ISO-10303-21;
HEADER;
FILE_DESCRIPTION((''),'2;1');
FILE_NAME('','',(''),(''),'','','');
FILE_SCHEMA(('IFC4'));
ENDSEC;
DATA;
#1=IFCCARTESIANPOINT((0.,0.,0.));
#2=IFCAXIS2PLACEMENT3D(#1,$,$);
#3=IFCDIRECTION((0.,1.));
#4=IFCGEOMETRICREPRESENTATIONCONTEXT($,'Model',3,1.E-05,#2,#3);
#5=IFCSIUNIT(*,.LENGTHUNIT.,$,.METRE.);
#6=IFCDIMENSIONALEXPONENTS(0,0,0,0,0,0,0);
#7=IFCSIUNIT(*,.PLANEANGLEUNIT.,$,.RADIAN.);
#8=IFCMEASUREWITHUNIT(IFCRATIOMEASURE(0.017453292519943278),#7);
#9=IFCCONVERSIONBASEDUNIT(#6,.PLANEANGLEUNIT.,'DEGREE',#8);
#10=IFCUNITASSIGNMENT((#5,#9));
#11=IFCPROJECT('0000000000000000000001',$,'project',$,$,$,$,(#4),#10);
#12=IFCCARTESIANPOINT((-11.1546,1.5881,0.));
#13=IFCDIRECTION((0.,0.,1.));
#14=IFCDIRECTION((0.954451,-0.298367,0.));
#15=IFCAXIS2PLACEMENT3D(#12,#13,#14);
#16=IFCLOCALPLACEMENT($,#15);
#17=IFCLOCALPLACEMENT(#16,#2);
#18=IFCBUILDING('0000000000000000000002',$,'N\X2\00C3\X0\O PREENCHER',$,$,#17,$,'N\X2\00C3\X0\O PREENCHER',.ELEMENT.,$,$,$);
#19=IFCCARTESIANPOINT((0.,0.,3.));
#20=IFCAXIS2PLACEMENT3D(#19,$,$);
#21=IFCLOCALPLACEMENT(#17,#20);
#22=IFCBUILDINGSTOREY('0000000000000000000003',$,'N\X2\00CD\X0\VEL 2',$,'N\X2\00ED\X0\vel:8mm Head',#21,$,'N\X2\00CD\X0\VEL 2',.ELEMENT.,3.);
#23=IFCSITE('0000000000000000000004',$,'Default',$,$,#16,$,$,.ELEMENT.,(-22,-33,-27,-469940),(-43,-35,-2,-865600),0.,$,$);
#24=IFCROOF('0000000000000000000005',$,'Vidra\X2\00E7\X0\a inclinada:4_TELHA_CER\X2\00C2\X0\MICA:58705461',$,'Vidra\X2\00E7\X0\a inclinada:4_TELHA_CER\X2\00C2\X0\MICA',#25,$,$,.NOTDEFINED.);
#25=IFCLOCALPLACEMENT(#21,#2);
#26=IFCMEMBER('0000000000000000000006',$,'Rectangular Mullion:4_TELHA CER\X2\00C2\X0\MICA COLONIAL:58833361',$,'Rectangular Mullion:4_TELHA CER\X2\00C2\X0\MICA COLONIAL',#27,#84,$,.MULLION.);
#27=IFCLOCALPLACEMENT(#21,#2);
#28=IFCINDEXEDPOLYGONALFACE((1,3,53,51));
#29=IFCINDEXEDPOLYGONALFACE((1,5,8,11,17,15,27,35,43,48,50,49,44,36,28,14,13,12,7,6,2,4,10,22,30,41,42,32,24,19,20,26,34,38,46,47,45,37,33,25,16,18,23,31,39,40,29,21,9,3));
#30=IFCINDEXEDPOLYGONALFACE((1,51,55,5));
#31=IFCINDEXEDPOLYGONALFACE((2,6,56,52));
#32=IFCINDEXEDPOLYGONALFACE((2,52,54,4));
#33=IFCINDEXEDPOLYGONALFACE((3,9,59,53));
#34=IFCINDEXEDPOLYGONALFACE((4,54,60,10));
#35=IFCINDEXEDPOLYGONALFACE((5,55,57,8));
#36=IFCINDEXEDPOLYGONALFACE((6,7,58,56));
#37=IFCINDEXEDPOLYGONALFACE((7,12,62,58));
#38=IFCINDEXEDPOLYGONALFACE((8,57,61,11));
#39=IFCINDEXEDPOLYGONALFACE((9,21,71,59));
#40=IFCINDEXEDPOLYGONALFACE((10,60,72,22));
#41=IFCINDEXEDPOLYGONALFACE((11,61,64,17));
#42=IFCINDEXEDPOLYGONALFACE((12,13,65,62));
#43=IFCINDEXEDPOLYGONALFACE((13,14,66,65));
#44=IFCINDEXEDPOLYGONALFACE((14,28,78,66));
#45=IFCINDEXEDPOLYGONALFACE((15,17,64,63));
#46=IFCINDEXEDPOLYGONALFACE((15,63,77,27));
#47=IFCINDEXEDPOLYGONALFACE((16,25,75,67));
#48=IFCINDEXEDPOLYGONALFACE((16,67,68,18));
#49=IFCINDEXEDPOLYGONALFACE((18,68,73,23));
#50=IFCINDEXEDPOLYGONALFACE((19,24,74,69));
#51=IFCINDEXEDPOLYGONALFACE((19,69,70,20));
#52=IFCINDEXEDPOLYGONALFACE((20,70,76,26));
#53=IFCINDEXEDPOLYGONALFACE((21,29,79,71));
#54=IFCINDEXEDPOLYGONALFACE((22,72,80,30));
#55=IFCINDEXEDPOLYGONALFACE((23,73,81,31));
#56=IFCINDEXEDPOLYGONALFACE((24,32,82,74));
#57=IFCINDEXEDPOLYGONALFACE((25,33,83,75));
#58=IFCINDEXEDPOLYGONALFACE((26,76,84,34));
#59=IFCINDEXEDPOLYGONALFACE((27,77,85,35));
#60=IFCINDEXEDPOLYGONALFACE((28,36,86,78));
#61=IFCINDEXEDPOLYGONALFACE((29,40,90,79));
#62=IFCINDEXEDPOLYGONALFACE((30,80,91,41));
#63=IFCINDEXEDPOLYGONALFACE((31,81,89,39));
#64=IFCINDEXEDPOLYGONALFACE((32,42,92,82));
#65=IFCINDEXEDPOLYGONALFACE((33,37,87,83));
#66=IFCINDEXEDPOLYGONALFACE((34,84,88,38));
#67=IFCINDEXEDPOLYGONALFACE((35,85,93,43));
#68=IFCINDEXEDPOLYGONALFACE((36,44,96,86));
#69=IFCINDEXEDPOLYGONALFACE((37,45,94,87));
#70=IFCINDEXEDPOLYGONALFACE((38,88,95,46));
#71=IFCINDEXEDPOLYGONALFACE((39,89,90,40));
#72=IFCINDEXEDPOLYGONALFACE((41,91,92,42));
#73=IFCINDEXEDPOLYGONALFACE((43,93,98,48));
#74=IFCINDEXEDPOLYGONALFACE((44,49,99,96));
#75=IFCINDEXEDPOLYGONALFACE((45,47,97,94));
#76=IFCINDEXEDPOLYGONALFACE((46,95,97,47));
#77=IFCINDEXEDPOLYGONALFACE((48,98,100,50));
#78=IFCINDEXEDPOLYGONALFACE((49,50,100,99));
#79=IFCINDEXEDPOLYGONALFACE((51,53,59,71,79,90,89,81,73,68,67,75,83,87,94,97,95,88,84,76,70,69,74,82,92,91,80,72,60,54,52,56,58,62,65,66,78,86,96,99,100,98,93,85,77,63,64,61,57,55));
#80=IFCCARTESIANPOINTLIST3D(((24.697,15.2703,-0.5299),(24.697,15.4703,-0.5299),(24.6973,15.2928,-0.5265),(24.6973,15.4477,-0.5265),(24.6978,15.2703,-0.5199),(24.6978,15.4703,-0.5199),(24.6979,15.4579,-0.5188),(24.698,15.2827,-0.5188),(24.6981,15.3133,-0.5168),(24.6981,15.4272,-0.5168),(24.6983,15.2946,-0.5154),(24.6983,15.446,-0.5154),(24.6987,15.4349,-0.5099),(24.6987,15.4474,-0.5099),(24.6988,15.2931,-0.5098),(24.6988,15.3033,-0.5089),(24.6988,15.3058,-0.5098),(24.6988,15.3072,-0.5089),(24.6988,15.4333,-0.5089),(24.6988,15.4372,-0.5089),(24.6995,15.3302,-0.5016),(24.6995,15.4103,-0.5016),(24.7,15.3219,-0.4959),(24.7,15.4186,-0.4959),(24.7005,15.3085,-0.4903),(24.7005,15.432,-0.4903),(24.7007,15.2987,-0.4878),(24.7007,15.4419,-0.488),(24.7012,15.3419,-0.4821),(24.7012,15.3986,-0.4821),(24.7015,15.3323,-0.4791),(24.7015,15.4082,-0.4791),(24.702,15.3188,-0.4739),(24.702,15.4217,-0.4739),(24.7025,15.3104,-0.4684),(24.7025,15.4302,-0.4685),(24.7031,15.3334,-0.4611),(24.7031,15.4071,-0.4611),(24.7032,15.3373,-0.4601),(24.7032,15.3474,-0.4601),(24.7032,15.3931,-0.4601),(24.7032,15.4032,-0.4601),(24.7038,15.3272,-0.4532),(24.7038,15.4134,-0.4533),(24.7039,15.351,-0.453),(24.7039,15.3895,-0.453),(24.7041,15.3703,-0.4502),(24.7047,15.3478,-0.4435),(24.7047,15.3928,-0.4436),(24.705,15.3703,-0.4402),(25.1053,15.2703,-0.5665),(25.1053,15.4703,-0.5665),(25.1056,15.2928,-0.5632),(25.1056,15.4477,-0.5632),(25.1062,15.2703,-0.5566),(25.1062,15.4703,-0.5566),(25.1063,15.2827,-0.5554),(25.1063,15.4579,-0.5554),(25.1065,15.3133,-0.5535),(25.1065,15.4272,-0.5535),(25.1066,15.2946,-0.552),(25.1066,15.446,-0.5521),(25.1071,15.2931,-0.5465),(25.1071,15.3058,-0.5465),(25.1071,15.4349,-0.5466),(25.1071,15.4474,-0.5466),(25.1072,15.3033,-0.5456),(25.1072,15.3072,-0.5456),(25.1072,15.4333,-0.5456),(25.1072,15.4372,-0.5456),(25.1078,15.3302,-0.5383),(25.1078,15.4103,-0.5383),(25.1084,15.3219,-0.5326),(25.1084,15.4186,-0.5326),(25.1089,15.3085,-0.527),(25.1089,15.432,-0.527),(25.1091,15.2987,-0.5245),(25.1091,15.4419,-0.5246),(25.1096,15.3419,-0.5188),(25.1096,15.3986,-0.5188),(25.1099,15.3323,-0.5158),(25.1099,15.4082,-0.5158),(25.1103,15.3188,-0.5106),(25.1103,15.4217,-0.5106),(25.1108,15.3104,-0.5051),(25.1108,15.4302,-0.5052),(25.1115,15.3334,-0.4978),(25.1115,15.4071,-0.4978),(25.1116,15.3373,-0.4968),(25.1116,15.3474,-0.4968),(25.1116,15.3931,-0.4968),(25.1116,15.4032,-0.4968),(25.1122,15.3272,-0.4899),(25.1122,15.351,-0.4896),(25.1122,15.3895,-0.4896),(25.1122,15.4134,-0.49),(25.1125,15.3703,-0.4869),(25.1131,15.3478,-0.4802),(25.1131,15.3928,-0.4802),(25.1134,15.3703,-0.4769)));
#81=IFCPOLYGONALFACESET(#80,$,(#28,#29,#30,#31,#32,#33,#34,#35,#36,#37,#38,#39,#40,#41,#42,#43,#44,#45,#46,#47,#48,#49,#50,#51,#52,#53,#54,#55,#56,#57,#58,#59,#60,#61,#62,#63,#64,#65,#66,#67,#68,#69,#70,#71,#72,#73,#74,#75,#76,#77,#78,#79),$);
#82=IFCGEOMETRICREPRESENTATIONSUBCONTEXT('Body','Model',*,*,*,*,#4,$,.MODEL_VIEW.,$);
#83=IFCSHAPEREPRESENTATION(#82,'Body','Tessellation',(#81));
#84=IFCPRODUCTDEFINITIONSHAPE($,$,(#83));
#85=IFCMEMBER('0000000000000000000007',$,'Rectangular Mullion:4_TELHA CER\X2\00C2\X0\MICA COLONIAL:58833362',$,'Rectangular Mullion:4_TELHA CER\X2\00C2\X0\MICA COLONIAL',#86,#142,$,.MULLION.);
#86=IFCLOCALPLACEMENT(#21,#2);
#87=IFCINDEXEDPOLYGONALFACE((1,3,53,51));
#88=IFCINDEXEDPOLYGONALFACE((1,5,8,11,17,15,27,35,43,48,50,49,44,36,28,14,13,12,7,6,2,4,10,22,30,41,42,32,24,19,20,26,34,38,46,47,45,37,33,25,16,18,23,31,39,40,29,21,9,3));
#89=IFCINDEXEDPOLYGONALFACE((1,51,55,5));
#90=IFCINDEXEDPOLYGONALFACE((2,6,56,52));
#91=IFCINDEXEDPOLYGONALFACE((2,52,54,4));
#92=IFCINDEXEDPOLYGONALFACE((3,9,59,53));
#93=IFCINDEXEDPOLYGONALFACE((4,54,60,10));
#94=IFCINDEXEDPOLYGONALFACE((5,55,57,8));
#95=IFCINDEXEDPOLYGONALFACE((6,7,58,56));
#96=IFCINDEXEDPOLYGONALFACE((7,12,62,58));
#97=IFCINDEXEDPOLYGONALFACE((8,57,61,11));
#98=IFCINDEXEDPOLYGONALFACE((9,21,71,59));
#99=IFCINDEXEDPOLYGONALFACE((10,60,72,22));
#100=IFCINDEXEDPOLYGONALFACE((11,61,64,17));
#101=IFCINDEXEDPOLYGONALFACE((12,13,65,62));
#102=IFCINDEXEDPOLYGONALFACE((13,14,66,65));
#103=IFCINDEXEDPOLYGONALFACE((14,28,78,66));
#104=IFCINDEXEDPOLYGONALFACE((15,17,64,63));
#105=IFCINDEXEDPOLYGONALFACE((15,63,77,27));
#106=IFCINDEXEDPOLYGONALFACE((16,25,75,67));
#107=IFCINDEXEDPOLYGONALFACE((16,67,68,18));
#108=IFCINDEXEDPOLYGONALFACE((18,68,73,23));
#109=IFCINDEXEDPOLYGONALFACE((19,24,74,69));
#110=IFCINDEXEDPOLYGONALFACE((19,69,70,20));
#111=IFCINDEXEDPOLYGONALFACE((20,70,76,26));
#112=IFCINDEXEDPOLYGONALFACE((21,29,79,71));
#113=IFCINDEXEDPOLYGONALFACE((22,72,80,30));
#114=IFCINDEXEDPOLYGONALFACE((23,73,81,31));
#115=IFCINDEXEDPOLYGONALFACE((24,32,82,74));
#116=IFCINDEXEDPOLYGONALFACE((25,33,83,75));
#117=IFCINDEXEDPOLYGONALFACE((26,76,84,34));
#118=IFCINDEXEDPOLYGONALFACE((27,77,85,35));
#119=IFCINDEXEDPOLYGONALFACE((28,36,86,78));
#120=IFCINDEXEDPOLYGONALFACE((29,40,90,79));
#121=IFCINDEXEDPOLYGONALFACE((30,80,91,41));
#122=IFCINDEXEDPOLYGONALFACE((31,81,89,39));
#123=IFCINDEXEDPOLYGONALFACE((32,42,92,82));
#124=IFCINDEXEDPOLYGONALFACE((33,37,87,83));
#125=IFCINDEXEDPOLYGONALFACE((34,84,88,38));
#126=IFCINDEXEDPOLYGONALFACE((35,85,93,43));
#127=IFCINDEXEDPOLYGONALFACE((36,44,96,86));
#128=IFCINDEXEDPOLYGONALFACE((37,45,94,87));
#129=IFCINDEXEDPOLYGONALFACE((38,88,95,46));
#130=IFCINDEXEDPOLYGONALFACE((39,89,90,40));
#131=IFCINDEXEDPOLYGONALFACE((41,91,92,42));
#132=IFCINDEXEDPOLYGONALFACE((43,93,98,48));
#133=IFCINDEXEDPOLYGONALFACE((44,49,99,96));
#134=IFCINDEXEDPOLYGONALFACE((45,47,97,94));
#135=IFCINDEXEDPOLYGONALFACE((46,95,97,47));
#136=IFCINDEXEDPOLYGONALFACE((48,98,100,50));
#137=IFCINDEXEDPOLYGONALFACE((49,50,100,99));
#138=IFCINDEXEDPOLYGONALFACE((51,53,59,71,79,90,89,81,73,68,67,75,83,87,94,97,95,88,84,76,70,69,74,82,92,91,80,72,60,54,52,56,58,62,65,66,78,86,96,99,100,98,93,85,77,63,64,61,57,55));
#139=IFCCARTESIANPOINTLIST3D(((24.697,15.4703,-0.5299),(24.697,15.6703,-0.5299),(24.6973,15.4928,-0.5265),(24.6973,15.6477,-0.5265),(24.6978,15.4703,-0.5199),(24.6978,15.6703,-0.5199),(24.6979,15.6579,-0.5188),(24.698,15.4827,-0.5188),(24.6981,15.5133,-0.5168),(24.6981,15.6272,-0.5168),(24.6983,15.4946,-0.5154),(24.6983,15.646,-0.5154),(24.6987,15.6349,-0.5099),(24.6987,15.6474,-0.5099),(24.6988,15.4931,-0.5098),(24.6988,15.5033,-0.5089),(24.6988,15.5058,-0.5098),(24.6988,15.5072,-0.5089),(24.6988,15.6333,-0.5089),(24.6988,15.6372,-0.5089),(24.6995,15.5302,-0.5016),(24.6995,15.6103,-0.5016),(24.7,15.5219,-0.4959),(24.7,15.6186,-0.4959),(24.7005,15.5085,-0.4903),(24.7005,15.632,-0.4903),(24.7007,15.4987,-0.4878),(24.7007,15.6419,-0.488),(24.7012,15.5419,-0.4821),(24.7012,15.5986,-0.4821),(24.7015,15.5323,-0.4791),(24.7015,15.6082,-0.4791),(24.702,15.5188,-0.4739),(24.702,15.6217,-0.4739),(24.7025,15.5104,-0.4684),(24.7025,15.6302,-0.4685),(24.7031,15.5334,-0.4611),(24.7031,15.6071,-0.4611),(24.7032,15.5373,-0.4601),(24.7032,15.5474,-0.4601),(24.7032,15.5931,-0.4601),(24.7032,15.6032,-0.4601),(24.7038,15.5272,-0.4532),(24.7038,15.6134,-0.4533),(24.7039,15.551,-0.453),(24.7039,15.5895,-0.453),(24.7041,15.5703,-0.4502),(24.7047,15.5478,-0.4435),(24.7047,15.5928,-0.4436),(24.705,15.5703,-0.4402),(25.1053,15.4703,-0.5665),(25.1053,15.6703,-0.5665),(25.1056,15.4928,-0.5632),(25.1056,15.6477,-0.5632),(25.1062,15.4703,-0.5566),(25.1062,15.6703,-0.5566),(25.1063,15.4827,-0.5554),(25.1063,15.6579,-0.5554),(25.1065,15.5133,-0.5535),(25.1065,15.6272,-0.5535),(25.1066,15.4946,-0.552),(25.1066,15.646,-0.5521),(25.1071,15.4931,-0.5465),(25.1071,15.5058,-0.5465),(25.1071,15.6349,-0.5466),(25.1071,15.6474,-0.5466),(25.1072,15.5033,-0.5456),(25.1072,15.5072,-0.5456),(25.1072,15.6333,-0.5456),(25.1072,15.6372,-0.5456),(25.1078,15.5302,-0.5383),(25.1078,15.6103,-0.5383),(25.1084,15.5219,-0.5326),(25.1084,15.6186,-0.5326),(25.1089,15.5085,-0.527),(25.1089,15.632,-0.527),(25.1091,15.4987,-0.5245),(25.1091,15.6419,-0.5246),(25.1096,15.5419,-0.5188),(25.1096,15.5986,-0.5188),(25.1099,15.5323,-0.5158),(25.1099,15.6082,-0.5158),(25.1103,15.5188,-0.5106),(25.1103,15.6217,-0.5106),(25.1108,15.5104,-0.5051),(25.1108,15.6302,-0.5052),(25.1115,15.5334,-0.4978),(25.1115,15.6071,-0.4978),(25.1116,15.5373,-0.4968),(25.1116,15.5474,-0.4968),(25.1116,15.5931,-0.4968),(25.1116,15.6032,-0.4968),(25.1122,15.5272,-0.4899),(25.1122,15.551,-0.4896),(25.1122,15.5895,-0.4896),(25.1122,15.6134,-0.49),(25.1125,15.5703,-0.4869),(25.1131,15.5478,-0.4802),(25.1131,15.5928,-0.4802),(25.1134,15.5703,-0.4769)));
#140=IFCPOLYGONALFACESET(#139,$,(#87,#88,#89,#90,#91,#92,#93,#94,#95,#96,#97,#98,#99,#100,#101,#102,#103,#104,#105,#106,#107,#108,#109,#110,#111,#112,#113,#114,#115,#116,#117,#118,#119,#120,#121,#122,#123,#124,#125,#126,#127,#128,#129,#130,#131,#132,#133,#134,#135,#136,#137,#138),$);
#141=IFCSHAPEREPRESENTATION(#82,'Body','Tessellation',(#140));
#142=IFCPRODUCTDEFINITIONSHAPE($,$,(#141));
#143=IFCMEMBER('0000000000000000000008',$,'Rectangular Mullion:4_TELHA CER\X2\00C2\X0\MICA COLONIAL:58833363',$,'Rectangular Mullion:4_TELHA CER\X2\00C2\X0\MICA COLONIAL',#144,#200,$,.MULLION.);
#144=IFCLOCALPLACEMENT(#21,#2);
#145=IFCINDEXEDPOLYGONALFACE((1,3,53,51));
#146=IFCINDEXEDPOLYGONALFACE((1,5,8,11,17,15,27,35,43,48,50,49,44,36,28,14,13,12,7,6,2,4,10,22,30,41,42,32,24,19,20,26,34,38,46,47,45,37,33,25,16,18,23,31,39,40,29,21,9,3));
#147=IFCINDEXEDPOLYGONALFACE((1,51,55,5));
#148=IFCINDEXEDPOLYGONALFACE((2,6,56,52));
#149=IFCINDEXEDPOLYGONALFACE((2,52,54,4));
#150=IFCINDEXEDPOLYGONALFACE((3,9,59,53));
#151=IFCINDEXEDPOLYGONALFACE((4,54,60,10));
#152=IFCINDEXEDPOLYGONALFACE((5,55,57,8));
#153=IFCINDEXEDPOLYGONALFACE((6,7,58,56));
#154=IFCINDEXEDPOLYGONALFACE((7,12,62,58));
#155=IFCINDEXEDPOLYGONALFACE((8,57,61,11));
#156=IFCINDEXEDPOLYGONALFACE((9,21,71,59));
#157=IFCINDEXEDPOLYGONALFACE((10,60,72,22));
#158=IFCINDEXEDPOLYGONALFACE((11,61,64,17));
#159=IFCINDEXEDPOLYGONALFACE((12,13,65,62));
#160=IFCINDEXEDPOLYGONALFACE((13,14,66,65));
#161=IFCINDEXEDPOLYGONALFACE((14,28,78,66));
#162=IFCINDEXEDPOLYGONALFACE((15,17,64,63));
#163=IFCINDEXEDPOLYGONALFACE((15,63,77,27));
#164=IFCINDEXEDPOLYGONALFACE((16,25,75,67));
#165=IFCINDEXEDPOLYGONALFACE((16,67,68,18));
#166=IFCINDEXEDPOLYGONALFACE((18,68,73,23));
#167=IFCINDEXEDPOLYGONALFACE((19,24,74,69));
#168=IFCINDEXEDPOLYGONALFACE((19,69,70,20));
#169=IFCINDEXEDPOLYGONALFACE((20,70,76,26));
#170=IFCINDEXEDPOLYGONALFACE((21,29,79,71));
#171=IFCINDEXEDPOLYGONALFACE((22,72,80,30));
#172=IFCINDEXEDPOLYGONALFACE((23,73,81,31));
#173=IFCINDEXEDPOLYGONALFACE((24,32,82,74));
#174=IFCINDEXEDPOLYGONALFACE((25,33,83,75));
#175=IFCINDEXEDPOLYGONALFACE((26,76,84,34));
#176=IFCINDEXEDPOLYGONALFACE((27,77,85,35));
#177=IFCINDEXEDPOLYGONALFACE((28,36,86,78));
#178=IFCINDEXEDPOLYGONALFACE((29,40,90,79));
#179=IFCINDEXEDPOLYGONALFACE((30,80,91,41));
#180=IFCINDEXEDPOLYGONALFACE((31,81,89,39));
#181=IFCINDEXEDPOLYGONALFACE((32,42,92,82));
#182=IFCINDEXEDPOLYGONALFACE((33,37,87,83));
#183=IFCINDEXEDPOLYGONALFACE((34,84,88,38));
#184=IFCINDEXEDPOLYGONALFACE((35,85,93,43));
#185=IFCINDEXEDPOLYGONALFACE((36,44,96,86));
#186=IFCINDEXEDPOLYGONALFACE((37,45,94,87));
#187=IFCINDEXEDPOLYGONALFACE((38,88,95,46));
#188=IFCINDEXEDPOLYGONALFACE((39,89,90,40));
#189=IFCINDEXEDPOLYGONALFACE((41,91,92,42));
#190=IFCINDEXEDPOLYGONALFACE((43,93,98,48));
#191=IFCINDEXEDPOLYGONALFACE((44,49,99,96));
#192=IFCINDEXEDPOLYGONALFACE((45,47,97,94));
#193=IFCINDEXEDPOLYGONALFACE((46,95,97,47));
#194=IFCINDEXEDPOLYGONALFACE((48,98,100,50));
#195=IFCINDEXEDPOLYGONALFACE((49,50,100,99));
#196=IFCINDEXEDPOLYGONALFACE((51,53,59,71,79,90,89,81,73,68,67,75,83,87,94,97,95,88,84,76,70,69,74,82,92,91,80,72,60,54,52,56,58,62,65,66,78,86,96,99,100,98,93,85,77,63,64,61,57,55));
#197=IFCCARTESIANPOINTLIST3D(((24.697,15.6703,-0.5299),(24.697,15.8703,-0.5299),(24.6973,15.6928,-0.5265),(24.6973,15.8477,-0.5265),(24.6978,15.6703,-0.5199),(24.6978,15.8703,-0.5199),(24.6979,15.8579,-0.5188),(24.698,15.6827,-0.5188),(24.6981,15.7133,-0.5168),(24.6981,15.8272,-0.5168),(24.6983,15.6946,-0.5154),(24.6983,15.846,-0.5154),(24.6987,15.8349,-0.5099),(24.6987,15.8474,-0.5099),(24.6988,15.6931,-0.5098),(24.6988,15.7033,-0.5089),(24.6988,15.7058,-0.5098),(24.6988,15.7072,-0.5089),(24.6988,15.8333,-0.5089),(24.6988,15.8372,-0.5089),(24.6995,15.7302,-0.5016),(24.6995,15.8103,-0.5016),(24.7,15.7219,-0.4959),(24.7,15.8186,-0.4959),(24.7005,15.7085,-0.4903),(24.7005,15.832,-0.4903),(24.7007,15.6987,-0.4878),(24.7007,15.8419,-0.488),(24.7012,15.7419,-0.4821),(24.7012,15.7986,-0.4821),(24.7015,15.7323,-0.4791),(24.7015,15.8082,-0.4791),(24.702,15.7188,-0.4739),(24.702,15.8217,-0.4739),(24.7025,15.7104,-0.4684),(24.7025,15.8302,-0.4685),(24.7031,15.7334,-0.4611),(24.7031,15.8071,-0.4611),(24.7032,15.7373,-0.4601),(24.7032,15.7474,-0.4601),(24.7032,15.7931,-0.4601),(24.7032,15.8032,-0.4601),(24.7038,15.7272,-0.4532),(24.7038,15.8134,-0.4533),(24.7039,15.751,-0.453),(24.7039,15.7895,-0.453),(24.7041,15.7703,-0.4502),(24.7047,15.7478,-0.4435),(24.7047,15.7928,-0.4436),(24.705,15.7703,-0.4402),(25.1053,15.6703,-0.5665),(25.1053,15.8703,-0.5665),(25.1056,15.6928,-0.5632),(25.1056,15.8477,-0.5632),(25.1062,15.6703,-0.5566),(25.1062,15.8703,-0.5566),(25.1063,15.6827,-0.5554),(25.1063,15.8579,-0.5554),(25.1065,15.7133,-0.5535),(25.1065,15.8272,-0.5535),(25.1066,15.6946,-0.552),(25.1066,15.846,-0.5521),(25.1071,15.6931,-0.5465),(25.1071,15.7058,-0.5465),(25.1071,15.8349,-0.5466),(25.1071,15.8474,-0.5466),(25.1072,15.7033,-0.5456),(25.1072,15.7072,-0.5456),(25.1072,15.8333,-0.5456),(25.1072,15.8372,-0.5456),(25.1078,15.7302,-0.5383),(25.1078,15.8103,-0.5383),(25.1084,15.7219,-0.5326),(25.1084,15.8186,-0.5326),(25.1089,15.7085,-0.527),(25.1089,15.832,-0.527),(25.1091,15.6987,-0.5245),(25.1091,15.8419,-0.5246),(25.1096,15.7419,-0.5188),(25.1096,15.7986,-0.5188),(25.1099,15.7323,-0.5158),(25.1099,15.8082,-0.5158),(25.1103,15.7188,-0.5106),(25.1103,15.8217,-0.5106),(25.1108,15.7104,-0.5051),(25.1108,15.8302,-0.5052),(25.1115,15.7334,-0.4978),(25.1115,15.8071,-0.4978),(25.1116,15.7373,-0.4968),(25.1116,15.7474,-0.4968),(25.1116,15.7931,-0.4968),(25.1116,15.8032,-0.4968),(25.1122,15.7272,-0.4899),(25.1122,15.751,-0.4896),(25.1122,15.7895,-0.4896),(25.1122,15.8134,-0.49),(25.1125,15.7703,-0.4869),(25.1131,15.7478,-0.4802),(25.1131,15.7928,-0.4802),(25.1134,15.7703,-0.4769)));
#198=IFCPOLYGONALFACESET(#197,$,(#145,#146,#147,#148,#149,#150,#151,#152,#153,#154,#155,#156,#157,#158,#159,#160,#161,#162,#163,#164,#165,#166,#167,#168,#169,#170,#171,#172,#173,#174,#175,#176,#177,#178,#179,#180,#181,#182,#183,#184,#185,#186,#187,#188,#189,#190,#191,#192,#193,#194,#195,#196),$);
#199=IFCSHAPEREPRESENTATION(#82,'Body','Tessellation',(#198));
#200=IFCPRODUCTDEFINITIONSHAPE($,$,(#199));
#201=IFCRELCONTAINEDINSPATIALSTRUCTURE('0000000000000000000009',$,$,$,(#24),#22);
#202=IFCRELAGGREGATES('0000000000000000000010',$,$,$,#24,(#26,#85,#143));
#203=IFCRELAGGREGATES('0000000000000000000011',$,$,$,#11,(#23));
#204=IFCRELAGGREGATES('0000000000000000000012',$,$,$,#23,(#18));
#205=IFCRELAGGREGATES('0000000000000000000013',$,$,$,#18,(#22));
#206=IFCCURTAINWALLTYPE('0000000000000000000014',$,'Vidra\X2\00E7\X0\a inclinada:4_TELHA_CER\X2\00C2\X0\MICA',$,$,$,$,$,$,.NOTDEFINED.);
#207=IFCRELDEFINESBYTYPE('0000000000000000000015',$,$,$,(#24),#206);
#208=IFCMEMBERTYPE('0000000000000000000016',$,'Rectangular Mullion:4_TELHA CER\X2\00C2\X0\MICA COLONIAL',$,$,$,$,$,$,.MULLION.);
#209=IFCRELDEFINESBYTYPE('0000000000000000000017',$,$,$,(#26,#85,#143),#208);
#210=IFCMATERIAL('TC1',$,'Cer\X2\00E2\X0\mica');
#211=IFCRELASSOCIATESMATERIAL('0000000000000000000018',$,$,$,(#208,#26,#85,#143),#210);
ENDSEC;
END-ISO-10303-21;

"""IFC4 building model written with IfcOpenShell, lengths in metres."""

from ifc_helpers import new_model, entity, si_unit, converted_unit, direction, frame, origin, place, context, subcontext, project, spatial, line, arc, indexed_curve, outline, extrude, source, transform, mapped, material, type_object, type_shapes, element, aggregate, save


model = new_model("IFC4")

# Units and contexts
model_context = context("Model", 3, precision=1e-05, world=origin(), true_north=direction((0.0, 1.0)))
body_context = subcontext(model_context, "Body", "Model", "MODEL_VIEW")
ifc_project = project(units=[si_unit("LENGTHUNIT", "METRE"), converted_unit("PLANEANGLEUNIT", "DEGREE", entity("IfcRatioMeasure", 0.017453292519943278), si_unit("PLANEANGLEUNIT", "RADIAN"), dimensions=[0, 0, 0, 0, 0, 0, 0])], contexts=[model_context])

# Site, building, storey
site_placement = place(None, frame((-11.1546, 1.5881, 0.0), z_axis=(0.0, 0.0, 1.0), x_axis=(0.954451, -0.298367, 0.0)))
site = spatial("IfcSite", under=ifc_project, at=site_placement, Name="Default", CompositionType="ELEMENT", RefLatitude=(-22, -33, -27, -469940), RefLongitude=(-43, -35, -2, -865600), RefElevation=0.0)
building_placement = place(site_placement, origin())
building = spatial("IfcBuilding", under=site, at=building_placement, Name="NÃO PREENCHER", LongName="NÃO PREENCHER", CompositionType="ELEMENT")
storey_placement = place(building_placement, frame((0.0, 0.0, 3.0)))
storey = spatial("IfcBuildingStorey", under=building, at=storey_placement, Name="NÍVEL 2", ObjectType="Nível:8mm Head", LongName="NÍVEL 2", CompositionType="ELEMENT", Elevation=3.0)

# Roof, members
curtain_wall_type = type_object("IfcCurtainWallType", Name="Vidraça inclinada:4_TELHA_CERÂMICA", PredefinedType="NOTDEFINED")
roof_placement = place(storey_placement, frame((0.0, 0.0, -3.0)))
roof = element("IfcRoof", 1, at=roof_placement, inside=storey, type_object=curtain_wall_type, Name="Vidraça inclinada:4_TELHA_CERÂMICA:58705461", ObjectType="Vidraça inclinada:4_TELHA_CERÂMICA", PredefinedType="NOTDEFINED")
ifc_material_1 = material(Name="TC1", Category="Cerâmica")
member_type_1 = type_object("IfcMemberType", Name="Rectangular Mullion:4_TELHA CERÂMICA COLONIAL", PredefinedType="MULLION", material=ifc_material_1)
shared_shape_1 = source(origin(), body_context, "Body", "SweptSolid", [
    extrude(outline(indexed_curve([(-0.029, -0.1), (-0.019, -0.1), (-0.0164, -0.0815), (-0.0089, -0.0645), (-0.0089, -0.0771), (0.061, 0.0), (-0.009, 0.0771), (-0.009, 0.0646), (-0.0165, 0.0816), (-0.019, 0.1), (-0.029, 0.1), (-0.0089, 0.0479), (0.041, 0.0229), (0.041, 0.0329), (0.0131, 0.0425), (-0.008, 0.0631), (-0.008, 0.067), (0.051, 0.0), (-0.008, -0.067), (-0.008, -0.0631), (0.0131, -0.0425), (0.041, -0.0329), (0.041, -0.0229), (-0.0089, -0.0479)], segments=[line(1, 2), arc(2, 3, 4), line(4, 5), arc(5, 6, 7), line(7, 8), arc(8, 9, 10), line(10, 11), arc(11, 12, 13), line(13, 14), arc(14, 15, 16), line(16, 17), arc(17, 18, 19), line(19, 20), arc(20, 21, 22), line(22, 23), arc(23, 24, 1)], self_intersect=False)), frame((0.0, -0.029, -0.41), z_axis=(0.0, 0.0, 1.0), x_axis=(0.0, -1.0, 0.0)), (0.0, 0.0, 1.0), 0.41),
])
type_shapes(member_type_1, [shared_shape_1])
member_1_placement = place(roof_placement, frame((24.697, 15.3703, 2.4701), z_axis=(-0.99599, 0.0, 0.089469), x_axis=(0.0, 1.0, 0.0)))
member_1 = element("IfcMember", 2, at=member_1_placement, type_object=member_type_1, material=ifc_material_1, Name="Rectangular Mullion:4_TELHA CERÂMICA COLONIAL:58833361", ObjectType="Rectangular Mullion:4_TELHA CERÂMICA COLONIAL", PredefinedType="MULLION", context=body_context, shape_type="MappedRepresentation", body=[
    mapped(shared_shape_1, transform((0.0, 0.0, 0.0), scale=1.0)),
])
member_2_placement = place(roof_placement, frame((24.697, 15.5703, 2.4701), z_axis=(-0.99599, 0.0, 0.089469), x_axis=(0.0, 1.0, 0.0)))
member_2 = element("IfcMember", 3, at=member_2_placement, type_object=member_type_1, material=ifc_material_1, Name="Rectangular Mullion:4_TELHA CERÂMICA COLONIAL:58833362", ObjectType="Rectangular Mullion:4_TELHA CERÂMICA COLONIAL", PredefinedType="MULLION", context=body_context, shape_type="MappedRepresentation", body=[
    mapped(shared_shape_1, transform((0.0, 0.0, 0.0), scale=1.0)),
])
member_3_placement = place(roof_placement, frame((24.697, 15.7703, 2.4701), z_axis=(-0.99599, 0.0, 0.089469), x_axis=(0.0, 1.0, 0.0)))
member_3 = element("IfcMember", 4, at=member_3_placement, type_object=member_type_1, material=ifc_material_1, Name="Rectangular Mullion:4_TELHA CERÂMICA COLONIAL:58833363", ObjectType="Rectangular Mullion:4_TELHA CERÂMICA COLONIAL", PredefinedType="MULLION", context=body_context, shape_type="MappedRepresentation", body=[
    mapped(shared_shape_1, transform((0.0, 0.0, 0.0), scale=1.0)),
])
aggregate(roof, [member_1, member_2, member_3])

save(model, "model.ifc")
